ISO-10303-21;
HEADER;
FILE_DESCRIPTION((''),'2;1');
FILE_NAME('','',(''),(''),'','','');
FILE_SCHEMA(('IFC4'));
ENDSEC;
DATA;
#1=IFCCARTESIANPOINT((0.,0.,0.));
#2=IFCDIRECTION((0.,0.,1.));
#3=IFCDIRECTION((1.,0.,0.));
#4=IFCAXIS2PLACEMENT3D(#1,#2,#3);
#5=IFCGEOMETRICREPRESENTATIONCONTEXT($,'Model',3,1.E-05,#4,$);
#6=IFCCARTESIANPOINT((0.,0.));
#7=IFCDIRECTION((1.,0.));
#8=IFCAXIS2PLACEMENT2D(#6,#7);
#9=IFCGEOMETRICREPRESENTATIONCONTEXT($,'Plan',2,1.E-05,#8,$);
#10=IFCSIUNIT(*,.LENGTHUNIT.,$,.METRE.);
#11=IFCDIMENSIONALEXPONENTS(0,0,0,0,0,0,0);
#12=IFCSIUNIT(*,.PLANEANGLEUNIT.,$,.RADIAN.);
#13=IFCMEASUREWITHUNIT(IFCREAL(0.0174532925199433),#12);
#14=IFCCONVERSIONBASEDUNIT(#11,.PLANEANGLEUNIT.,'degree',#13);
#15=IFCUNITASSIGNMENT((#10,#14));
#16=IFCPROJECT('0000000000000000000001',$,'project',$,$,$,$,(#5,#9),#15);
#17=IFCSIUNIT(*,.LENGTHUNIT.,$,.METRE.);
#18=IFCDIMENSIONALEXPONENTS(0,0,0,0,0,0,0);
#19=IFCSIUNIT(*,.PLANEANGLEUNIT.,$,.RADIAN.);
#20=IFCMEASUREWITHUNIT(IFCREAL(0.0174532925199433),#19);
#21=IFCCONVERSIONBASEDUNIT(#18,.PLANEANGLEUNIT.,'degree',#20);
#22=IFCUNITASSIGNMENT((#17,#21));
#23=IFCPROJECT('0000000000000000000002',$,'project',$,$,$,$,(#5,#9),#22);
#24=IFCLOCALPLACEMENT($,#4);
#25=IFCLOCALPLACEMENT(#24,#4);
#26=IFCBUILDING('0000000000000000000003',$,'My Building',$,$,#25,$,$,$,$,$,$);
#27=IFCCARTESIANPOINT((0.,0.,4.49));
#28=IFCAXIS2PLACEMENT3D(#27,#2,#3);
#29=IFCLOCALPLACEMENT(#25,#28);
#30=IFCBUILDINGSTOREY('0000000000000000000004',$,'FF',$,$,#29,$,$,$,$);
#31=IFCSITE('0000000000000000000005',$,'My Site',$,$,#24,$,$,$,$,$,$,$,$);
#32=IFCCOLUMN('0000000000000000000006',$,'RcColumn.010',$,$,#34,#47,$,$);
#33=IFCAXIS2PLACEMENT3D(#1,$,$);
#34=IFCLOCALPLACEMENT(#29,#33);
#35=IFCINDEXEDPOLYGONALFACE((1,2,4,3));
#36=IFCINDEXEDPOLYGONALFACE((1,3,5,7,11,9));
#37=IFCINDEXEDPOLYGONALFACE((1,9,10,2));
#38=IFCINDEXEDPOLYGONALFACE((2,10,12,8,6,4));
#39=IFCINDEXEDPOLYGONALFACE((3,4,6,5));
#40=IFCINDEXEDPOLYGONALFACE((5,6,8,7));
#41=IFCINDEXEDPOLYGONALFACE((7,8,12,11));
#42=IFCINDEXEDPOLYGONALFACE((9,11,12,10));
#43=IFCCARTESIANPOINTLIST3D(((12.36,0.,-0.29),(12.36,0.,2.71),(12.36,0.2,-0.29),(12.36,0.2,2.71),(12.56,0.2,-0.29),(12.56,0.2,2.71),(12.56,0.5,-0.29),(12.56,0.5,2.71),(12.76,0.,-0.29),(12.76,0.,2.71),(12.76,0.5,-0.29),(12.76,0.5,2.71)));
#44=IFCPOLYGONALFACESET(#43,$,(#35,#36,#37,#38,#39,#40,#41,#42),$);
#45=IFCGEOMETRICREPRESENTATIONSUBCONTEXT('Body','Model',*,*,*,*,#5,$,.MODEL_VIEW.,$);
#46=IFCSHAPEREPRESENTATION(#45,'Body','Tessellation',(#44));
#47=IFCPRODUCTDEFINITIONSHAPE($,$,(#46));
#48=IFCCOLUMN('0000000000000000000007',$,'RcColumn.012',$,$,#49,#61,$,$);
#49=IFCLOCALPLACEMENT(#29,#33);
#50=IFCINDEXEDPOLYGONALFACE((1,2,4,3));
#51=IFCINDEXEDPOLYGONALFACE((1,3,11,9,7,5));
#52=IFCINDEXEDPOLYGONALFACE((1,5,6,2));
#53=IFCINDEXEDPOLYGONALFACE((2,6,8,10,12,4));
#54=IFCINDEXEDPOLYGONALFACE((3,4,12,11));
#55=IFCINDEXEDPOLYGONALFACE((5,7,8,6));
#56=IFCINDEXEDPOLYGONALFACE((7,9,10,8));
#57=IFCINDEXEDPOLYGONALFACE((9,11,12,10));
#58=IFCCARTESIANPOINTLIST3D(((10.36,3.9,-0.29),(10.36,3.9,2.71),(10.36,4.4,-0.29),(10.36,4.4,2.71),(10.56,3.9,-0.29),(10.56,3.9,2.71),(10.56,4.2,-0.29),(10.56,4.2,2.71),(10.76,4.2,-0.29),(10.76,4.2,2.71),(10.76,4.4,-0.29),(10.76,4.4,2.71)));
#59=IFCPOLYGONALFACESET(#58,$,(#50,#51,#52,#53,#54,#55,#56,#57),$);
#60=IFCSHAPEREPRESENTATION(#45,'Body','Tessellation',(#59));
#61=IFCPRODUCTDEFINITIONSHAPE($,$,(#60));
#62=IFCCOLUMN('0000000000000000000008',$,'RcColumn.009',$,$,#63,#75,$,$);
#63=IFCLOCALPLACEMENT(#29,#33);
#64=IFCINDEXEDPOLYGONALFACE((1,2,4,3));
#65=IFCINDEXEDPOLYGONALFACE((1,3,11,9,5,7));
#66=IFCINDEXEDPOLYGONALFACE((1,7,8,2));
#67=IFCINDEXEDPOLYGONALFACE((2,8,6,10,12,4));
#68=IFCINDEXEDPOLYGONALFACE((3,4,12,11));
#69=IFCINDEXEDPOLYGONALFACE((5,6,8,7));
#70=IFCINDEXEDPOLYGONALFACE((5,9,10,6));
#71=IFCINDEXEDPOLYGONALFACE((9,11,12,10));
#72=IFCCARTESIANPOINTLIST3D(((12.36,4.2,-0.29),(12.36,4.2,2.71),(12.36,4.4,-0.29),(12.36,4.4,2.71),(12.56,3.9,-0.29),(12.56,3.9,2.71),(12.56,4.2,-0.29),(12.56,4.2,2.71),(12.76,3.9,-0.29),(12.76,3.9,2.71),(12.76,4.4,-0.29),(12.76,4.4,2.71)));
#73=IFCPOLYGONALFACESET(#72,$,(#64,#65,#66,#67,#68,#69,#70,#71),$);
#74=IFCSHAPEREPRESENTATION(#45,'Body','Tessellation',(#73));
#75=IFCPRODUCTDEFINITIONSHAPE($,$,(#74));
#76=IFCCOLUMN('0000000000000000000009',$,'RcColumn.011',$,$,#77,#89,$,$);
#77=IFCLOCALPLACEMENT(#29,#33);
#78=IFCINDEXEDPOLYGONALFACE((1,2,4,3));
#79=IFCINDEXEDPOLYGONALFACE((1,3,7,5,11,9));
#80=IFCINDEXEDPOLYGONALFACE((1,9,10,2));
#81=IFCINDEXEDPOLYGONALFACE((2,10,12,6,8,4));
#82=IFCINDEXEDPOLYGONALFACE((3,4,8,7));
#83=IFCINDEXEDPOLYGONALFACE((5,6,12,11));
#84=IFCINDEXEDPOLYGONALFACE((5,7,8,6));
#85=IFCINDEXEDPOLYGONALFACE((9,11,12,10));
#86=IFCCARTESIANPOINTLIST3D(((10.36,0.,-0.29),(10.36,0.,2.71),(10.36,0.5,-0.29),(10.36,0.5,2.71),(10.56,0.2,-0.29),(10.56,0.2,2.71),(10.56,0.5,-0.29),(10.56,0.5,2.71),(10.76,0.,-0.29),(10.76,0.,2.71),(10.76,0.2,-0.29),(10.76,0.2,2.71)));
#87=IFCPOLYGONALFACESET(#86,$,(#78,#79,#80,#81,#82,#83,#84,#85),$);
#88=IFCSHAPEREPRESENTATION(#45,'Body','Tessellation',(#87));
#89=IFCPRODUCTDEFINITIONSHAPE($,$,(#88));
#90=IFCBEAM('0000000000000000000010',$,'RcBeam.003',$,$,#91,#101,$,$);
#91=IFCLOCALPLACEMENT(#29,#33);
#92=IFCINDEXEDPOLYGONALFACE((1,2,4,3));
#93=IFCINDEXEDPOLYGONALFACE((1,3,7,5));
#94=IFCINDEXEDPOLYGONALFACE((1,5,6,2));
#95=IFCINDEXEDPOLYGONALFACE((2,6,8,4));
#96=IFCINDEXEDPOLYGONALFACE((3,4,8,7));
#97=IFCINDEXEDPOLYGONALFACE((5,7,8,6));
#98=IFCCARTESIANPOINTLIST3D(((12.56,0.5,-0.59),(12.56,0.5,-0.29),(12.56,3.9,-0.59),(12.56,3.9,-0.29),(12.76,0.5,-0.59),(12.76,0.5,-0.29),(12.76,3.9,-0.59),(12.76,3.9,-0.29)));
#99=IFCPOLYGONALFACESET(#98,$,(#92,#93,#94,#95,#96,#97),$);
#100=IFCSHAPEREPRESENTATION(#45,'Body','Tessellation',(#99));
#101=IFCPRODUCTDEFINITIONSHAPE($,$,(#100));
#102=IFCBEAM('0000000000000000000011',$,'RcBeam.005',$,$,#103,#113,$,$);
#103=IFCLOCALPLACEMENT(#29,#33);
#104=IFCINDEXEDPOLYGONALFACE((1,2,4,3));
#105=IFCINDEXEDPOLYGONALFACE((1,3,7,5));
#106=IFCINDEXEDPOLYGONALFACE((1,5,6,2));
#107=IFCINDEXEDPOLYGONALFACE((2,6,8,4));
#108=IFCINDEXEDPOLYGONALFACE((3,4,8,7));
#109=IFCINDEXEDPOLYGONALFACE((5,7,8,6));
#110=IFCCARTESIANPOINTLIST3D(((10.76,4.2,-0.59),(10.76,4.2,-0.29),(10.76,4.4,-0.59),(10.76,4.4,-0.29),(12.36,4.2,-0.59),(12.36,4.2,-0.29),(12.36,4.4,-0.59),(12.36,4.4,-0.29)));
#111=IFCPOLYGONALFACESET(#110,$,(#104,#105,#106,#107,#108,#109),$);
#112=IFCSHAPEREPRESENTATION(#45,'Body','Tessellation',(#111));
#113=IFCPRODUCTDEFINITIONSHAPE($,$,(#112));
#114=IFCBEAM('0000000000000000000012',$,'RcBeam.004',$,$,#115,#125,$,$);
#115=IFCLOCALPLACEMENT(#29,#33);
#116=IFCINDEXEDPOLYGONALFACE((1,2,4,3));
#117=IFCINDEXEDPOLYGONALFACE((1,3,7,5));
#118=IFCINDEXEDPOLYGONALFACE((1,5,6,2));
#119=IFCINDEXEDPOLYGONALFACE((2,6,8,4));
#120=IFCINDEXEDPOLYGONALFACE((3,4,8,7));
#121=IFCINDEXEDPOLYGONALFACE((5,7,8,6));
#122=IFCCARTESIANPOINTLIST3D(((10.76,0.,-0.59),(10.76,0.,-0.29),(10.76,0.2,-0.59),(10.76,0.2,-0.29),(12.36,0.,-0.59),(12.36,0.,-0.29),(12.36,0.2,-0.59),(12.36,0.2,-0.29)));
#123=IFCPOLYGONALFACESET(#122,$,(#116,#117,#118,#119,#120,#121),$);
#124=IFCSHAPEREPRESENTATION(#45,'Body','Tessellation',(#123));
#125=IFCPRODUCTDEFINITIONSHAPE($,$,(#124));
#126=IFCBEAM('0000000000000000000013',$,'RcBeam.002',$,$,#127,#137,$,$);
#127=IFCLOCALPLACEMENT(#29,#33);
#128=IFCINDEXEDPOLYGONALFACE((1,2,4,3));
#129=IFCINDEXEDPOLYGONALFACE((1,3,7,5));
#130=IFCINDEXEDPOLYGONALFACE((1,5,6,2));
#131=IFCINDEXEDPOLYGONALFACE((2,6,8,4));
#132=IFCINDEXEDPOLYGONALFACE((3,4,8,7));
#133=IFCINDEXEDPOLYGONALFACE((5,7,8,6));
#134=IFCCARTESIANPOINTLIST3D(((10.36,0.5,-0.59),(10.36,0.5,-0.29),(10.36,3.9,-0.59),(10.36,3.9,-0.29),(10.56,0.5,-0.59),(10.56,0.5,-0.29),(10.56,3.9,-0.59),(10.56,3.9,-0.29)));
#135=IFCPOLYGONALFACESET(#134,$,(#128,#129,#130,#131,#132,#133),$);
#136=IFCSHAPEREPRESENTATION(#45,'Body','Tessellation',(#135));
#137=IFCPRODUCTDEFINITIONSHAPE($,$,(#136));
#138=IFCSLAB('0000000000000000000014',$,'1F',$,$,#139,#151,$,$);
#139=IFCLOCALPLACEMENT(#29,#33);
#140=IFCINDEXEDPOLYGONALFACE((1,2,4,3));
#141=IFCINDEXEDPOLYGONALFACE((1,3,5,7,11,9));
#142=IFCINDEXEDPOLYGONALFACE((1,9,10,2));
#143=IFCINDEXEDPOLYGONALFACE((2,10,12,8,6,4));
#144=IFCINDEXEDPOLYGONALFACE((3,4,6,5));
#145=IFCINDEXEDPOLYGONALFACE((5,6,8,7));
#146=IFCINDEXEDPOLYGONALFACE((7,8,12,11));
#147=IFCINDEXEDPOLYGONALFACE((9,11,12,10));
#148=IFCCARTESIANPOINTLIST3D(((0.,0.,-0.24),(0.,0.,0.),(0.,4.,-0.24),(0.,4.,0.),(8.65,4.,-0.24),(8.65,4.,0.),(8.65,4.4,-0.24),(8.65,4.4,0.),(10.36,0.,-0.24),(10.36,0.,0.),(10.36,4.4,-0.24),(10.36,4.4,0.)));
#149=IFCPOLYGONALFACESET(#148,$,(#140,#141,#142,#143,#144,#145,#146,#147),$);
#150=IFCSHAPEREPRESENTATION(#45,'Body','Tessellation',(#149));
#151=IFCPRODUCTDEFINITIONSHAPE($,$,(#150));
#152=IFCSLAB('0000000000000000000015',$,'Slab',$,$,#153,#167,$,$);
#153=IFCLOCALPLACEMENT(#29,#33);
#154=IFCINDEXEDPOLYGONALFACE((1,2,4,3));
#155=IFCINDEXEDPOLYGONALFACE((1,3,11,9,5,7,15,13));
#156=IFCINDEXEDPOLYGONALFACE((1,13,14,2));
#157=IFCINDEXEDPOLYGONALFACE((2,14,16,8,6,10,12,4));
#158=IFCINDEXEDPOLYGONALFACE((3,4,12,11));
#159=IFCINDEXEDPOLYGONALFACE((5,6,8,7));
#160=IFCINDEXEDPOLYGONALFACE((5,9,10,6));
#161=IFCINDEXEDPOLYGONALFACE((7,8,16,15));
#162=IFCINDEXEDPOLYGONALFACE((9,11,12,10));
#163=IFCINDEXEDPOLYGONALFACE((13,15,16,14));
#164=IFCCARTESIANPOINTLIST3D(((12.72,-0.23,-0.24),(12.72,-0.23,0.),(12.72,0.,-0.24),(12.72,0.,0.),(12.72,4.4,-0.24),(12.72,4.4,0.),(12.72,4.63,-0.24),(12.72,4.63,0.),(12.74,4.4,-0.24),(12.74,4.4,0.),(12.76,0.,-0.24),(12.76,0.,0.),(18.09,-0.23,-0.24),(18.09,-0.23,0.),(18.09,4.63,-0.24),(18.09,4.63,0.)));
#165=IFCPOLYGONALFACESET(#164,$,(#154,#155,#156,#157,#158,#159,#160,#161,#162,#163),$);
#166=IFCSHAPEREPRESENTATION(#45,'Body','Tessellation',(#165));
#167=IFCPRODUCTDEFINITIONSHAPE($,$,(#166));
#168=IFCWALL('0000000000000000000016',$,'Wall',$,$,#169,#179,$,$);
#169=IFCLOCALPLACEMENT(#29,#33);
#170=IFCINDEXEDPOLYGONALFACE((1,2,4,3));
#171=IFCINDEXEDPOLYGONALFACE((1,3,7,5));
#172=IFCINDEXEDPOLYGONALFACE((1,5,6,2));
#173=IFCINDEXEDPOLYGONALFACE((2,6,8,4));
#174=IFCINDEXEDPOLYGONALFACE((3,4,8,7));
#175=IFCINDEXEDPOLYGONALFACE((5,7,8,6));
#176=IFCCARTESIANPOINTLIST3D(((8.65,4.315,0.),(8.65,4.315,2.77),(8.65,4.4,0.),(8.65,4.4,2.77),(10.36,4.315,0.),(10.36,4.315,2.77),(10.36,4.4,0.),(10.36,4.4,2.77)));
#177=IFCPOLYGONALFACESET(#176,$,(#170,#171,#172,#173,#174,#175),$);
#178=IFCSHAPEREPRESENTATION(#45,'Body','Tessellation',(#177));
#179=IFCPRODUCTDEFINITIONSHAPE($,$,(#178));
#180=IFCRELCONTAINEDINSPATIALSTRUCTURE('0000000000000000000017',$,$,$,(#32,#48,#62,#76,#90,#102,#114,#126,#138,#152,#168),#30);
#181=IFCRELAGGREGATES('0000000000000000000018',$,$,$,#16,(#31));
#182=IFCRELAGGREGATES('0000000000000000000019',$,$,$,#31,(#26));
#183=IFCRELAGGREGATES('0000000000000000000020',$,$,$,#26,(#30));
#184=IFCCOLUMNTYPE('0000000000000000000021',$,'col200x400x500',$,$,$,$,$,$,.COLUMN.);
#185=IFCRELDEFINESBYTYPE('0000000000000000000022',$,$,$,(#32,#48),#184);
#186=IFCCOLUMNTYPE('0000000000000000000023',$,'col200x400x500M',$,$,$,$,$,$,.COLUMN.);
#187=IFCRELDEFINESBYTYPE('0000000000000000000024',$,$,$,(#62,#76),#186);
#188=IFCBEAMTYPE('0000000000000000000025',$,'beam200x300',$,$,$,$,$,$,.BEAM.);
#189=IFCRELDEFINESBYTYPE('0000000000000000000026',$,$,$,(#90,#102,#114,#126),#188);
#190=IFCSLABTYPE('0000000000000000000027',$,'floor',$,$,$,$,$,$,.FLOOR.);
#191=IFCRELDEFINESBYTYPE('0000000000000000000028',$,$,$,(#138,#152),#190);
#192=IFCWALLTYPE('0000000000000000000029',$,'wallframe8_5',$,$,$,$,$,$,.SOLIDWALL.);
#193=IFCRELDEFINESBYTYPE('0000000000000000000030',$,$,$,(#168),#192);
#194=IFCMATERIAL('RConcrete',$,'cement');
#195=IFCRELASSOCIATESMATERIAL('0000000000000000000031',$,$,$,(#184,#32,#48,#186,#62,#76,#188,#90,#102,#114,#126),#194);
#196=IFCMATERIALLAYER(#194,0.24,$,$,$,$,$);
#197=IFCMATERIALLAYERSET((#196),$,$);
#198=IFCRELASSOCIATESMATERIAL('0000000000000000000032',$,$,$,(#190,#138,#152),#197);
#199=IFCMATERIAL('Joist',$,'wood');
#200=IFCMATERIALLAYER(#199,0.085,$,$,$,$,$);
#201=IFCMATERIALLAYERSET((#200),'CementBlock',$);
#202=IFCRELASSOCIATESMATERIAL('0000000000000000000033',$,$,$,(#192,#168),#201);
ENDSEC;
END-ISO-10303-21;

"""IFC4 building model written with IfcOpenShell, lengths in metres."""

from ifc_helpers import new_model, entity, si_unit, converted_unit, frame, origin_with_axes, origin_2d_with_axis, place, context, subcontext, project, spatial, line, indexed_curve, rectangle, outline, extrude, material, layer, layer_set, layer_usage, material_profile, profile_set, profile_usage, type_object, element, save


model = new_model("IFC4")

# Units and contexts
model_context = context("Model", 3, precision=1e-05, world=origin_with_axes())
plan_context = context("Plan", 2, precision=1e-05, world=origin_2d_with_axis())
body_context = subcontext(model_context, "Body", "Model", "MODEL_VIEW")
ifc_project_1 = project(units=[si_unit("LENGTHUNIT", "METRE"), converted_unit("PLANEANGLEUNIT", "degree", entity("IfcReal", 0.0174532925199433), si_unit("PLANEANGLEUNIT", "RADIAN"), dimensions=[0, 0, 0, 0, 0, 0, 0])], contexts=[model_context, plan_context])
ifc_project_2 = project(units=[si_unit("LENGTHUNIT", "METRE"), converted_unit("PLANEANGLEUNIT", "degree", entity("IfcReal", 0.0174532925199433), si_unit("PLANEANGLEUNIT", "RADIAN"), dimensions=[0, 0, 0, 0, 0, 0, 0])], contexts=[model_context, plan_context])

# Site, building, storey
site_placement = place(None, origin_with_axes())
site = spatial("IfcSite", under=ifc_project_1, at=site_placement, Name="My Site")
building_placement = place(site_placement, origin_with_axes())
building = spatial("IfcBuilding", under=site, at=building_placement, Name="My Building")
storey_placement = place(building_placement, frame((0.0, 0.0, 4.49), z_axis=(0.0, 0.0, 1.0), x_axis=(1.0, 0.0, 0.0)))
storey = spatial("IfcBuildingStorey", under=building, at=storey_placement, Name="FF")

# Columns
ifc_material_1 = material(Name="RConcrete", Category="cement")
ifc_material_profile_1 = material_profile(ifc_material_1, outline(indexed_curve([(0.2, 0.4), (0.2, 0.2), (0.5, 0.2), (0.5, 0.0), (0.0, 0.0), (0.0, 0.4)], segments=[line(6, 5), line(5, 4), line(4, 3), line(3, 2), line(2, 1), line(1, 6)], self_intersect=False)))
ifc_profile_set_1 = profile_set([ifc_material_profile_1], Name="RConcrete")
ifc_profile_usage_1 = profile_usage(ifc_profile_set_1, cardinal=5)
column_type_1 = type_object("IfcColumnType", Name="col200x400x500", PredefinedType="COLUMN", material=ifc_profile_set_1)
column_1_placement = place(storey_placement, frame((12.76, 0.0, -0.29), z_axis=(0.0, 0.0, 1.0), x_axis=(0.000001, 1.0, 0.0)))
element("IfcColumn", 1, at=column_1_placement, inside=storey, type_object=column_type_1, material=ifc_profile_usage_1, Name="RcColumn.010", context=body_context, shape_type="SweptSolid", body=[
    extrude(outline(indexed_curve([(0.2, 0.4), (0.2, 0.2), (0.5, 0.2), (0.5, 0.0), (0.0, 0.0), (0.0, 0.4)], segments=[line(6, 5), line(5, 4), line(4, 3), line(3, 2), line(2, 1), line(1, 6)], self_intersect=False)), origin_with_axes(), (0.0, 0.0, 1.0), 3.0),
])
ifc_profile_usage_2 = profile_usage(ifc_profile_set_1, cardinal=5)
column_2_placement = place(storey_placement, frame((10.36, 4.4, -0.29), z_axis=(0.0, 0.0, 1.0), x_axis=(0.0, -1.0, 0.0)))
element("IfcColumn", 2, at=column_2_placement, inside=storey, type_object=column_type_1, material=ifc_profile_usage_2, Name="RcColumn.012", context=body_context, shape_type="SweptSolid", body=[
    extrude(outline(indexed_curve([(0.2, 0.4), (0.2, 0.2), (0.5, 0.2), (0.5, 0.0), (0.0, 0.0), (0.0, 0.4)], segments=[line(6, 5), line(5, 4), line(4, 3), line(3, 2), line(2, 1), line(1, 6)], self_intersect=False)), origin_with_axes(), (0.0, 0.0, 1.0), 3.0),
])
ifc_material_profile_2 = material_profile(ifc_material_1, outline(indexed_curve([(0.0, 0.5), (0.0, 0.0), (0.4, 0.0), (0.4, 0.2), (0.2, 0.2), (0.2, 0.5)], segments=[line(5, 4), line(4, 3), line(3, 2), line(2, 1), line(1, 6), line(6, 5)], self_intersect=False)))
ifc_profile_set_2 = profile_set([ifc_material_profile_2], Name="RConcrete")
ifc_profile_usage_3 = profile_usage(ifc_profile_set_2, cardinal=5)
column_type_2 = type_object("IfcColumnType", Name="col200x400x500M", PredefinedType="COLUMN", material=ifc_profile_set_2)
column_3_placement = place(storey_placement, frame((12.76, 4.4, -0.29), z_axis=(0.0, 0.0, 1.0), x_axis=(-1.0, 0.0, 0.0)))
element("IfcColumn", 3, at=column_3_placement, inside=storey, type_object=column_type_2, material=ifc_profile_usage_3, Name="RcColumn.009", context=body_context, shape_type="SweptSolid", body=[
    extrude(outline(indexed_curve([(0.0, 0.5), (0.0, 0.0), (0.4, 0.0), (0.4, 0.2), (0.2, 0.2), (0.2, 0.5)], segments=[line(5, 4), line(4, 3), line(3, 2), line(2, 1), line(1, 6), line(6, 5)], self_intersect=False)), origin_with_axes(), (0.0, 0.0, 1.0), 3.0),
])
ifc_profile_usage_4 = profile_usage(ifc_profile_set_2, cardinal=5)
column_4_placement = place(storey_placement, frame((10.36, 0.0, -0.29), z_axis=(0.0, 0.0, 1.0), x_axis=(1.0, 0.0, 0.0)))
element("IfcColumn", 4, at=column_4_placement, inside=storey, type_object=column_type_2, material=ifc_profile_usage_4, Name="RcColumn.011", context=body_context, shape_type="SweptSolid", body=[
    extrude(outline(indexed_curve([(0.0, 0.5), (0.0, 0.0), (0.4, 0.0), (0.4, 0.2), (0.2, 0.2), (0.2, 0.5)], segments=[line(5, 4), line(4, 3), line(3, 2), line(2, 1), line(1, 6), line(6, 5)], self_intersect=False)), origin_with_axes(), (0.0, 0.0, 1.0), 3.0),
])

# Beams
ifc_material_profile_3 = material_profile(ifc_material_1, rectangle(XDim=0.2, YDim=0.3))
ifc_profile_set_3 = profile_set([ifc_material_profile_3], Name="RConcrete")
ifc_profile_usage_5 = profile_usage(ifc_profile_set_3, cardinal=1)
beam_type = type_object("IfcBeamType", Name="beam200x300", PredefinedType="BEAM", material=ifc_profile_set_3)
beam_1_placement = place(storey_placement, frame((12.76, 3.9, -0.59), z_axis=(0.0, -1.0, 0.0), x_axis=(1.0, 0.0, 0.0)))
element("IfcBeam", 5, at=beam_1_placement, inside=storey, type_object=beam_type, material=ifc_profile_usage_5, Name="RcBeam.003", context=body_context, shape_type="SweptSolid", body=[
    extrude(rectangle(XDim=0.2, YDim=0.3), frame((-0.1, 0.15, 0.0), z_axis=(0.0, 0.0, 1.0), x_axis=(1.0, 0.0, 0.0)), (0.0, 0.0, 1.0), 3.4),
])
ifc_profile_usage_6 = profile_usage(ifc_profile_set_3, cardinal=1)
beam_2_placement = place(storey_placement, frame((10.76, 4.4, -0.59), z_axis=(1.0, 0.0, 0.0), x_axis=(0.0, 1.0, 0.0)))
element("IfcBeam", 6, at=beam_2_placement, inside=storey, type_object=beam_type, material=ifc_profile_usage_6, Name="RcBeam.005", context=body_context, shape_type="SweptSolid", body=[
    extrude(rectangle(XDim=0.2, YDim=0.3), frame((-0.1, 0.15, 0.0), z_axis=(0.0, 0.0, 1.0), x_axis=(1.0, 0.0, 0.0)), (0.0, 0.0, 1.0), 1.6),
])
ifc_profile_usage_7 = profile_usage(ifc_profile_set_3, cardinal=1)
beam_3_placement = place(storey_placement, frame((10.76, 0.2, -0.59), z_axis=(1.0, 0.0, 0.0), x_axis=(0.0, 1.0, 0.0)))
element("IfcBeam", 7, at=beam_3_placement, inside=storey, type_object=beam_type, material=ifc_profile_usage_7, Name="RcBeam.004", context=body_context, shape_type="SweptSolid", body=[
    extrude(rectangle(XDim=0.2, YDim=0.3), frame((-0.1, 0.15, 0.0), z_axis=(0.0, 0.0, 1.0), x_axis=(1.0, 0.0, 0.0)), (0.0, 0.0, 1.0), 1.6),
])
ifc_profile_usage_8 = profile_usage(ifc_profile_set_3, cardinal=1)
beam_4_placement = place(storey_placement, frame((10.56, 3.9, -0.59), z_axis=(0.0, -1.0, 0.0), x_axis=(1.0, 0.0, 0.0)))
element("IfcBeam", 8, at=beam_4_placement, inside=storey, type_object=beam_type, material=ifc_profile_usage_8, Name="RcBeam.002", context=body_context, shape_type="SweptSolid", body=[
    extrude(rectangle(XDim=0.2, YDim=0.3), frame((-0.1, 0.15, 0.0), z_axis=(0.0, 0.0, 1.0), x_axis=(1.0, 0.0, 0.0)), (0.0, 0.0, 1.0), 3.4),
])

# Slabs
ifc_layer_1 = layer(ifc_material_1, 0.24)
ifc_layer_set_1 = layer_set([ifc_layer_1])
ifc_layer_usage_1 = layer_usage(ifc_layer_set_1, "AXIS3", "POSITIVE", 0.0)
slab_type = type_object("IfcSlabType", Name="floor", PredefinedType="FLOOR", material=ifc_layer_set_1)
slab_1_placement = place(storey_placement, frame((0.0, 0.0, -0.24), z_axis=(0.0, 0.0, 1.0), x_axis=(1.0, 0.0, 0.0)))
element("IfcSlab", 9, at=slab_1_placement, inside=storey, type_object=slab_type, material=ifc_layer_usage_1, Name="1F", context=body_context, shape_type="SweptSolid", body=[
    extrude(outline(indexed_curve([(0.0, 0.0), (10.36, 0.0), (10.36, 4.4), (0.0, 4.0), (8.65, 4.0), (8.65, 4.4)], segments=[line(1, 4), line(4, 5), line(5, 6), line(6, 3), line(3, 2), line(2, 1)], self_intersect=False)), None, (0.0, 0.0, 1.0), 0.24),
])
ifc_layer_usage_2 = layer_usage(ifc_layer_set_1, "AXIS3", "POSITIVE", 0.0)
slab_2_placement = place(storey_placement, frame((12.72, -0.23, -0.24), z_axis=(0.0, 0.0, 1.0), x_axis=(1.0, 0.0, 0.0)))
element("IfcSlab", 10, at=slab_2_placement, inside=storey, type_object=slab_type, material=ifc_layer_usage_2, Name="Slab", context=body_context, shape_type="SweptSolid", body=[
    extrude(outline(indexed_curve([(5.37, 4.86), (5.37, 0.0), (0.0, 0.0), (0.0, 4.86), (0.0, 0.23), (0.04, 0.23), (0.0, 4.63), (0.02, 4.63)], segments=[line(4, 7), line(7, 8), line(8, 6), line(6, 5), line(5, 3), line(3, 2), line(2, 1), line(1, 4)], self_intersect=False)), None, (0.0, 0.0, 1.0), 0.24),
])

# Wall
ifc_material_2 = material(Name="Joist", Category="wood")
ifc_layer_2 = layer(ifc_material_2, 0.085)
ifc_layer_set_2 = layer_set([ifc_layer_2], Name="CementBlock")
ifc_layer_usage_3 = layer_usage(ifc_layer_set_2, "AXIS2", "POSITIVE", 0.0)
wall_type = type_object("IfcWallType", Name="wallframe8_5", PredefinedType="SOLIDWALL", material=ifc_layer_set_2)
wall_1_placement = place(storey_placement, frame((10.36, 4.4, 0.0), z_axis=(0.0, 0.0, 1.0), x_axis=(-1.0, 0.0, 0.0)))
element("IfcWall", 11, at=wall_1_placement, inside=storey, type_object=wall_type, material=ifc_layer_usage_3, Name="Wall", context=body_context, shape_type="SweptSolid", body=[
    extrude(outline(indexed_curve([(0.0, 0.0), (0.0, 0.085), (1.71, 0.085), (1.71, 0.0), (0.0, 0.0)], self_intersect=False)), origin_with_axes(), (0.0, 0.0, 1.0), 2.77),
])

save(model, "model.ifc")
